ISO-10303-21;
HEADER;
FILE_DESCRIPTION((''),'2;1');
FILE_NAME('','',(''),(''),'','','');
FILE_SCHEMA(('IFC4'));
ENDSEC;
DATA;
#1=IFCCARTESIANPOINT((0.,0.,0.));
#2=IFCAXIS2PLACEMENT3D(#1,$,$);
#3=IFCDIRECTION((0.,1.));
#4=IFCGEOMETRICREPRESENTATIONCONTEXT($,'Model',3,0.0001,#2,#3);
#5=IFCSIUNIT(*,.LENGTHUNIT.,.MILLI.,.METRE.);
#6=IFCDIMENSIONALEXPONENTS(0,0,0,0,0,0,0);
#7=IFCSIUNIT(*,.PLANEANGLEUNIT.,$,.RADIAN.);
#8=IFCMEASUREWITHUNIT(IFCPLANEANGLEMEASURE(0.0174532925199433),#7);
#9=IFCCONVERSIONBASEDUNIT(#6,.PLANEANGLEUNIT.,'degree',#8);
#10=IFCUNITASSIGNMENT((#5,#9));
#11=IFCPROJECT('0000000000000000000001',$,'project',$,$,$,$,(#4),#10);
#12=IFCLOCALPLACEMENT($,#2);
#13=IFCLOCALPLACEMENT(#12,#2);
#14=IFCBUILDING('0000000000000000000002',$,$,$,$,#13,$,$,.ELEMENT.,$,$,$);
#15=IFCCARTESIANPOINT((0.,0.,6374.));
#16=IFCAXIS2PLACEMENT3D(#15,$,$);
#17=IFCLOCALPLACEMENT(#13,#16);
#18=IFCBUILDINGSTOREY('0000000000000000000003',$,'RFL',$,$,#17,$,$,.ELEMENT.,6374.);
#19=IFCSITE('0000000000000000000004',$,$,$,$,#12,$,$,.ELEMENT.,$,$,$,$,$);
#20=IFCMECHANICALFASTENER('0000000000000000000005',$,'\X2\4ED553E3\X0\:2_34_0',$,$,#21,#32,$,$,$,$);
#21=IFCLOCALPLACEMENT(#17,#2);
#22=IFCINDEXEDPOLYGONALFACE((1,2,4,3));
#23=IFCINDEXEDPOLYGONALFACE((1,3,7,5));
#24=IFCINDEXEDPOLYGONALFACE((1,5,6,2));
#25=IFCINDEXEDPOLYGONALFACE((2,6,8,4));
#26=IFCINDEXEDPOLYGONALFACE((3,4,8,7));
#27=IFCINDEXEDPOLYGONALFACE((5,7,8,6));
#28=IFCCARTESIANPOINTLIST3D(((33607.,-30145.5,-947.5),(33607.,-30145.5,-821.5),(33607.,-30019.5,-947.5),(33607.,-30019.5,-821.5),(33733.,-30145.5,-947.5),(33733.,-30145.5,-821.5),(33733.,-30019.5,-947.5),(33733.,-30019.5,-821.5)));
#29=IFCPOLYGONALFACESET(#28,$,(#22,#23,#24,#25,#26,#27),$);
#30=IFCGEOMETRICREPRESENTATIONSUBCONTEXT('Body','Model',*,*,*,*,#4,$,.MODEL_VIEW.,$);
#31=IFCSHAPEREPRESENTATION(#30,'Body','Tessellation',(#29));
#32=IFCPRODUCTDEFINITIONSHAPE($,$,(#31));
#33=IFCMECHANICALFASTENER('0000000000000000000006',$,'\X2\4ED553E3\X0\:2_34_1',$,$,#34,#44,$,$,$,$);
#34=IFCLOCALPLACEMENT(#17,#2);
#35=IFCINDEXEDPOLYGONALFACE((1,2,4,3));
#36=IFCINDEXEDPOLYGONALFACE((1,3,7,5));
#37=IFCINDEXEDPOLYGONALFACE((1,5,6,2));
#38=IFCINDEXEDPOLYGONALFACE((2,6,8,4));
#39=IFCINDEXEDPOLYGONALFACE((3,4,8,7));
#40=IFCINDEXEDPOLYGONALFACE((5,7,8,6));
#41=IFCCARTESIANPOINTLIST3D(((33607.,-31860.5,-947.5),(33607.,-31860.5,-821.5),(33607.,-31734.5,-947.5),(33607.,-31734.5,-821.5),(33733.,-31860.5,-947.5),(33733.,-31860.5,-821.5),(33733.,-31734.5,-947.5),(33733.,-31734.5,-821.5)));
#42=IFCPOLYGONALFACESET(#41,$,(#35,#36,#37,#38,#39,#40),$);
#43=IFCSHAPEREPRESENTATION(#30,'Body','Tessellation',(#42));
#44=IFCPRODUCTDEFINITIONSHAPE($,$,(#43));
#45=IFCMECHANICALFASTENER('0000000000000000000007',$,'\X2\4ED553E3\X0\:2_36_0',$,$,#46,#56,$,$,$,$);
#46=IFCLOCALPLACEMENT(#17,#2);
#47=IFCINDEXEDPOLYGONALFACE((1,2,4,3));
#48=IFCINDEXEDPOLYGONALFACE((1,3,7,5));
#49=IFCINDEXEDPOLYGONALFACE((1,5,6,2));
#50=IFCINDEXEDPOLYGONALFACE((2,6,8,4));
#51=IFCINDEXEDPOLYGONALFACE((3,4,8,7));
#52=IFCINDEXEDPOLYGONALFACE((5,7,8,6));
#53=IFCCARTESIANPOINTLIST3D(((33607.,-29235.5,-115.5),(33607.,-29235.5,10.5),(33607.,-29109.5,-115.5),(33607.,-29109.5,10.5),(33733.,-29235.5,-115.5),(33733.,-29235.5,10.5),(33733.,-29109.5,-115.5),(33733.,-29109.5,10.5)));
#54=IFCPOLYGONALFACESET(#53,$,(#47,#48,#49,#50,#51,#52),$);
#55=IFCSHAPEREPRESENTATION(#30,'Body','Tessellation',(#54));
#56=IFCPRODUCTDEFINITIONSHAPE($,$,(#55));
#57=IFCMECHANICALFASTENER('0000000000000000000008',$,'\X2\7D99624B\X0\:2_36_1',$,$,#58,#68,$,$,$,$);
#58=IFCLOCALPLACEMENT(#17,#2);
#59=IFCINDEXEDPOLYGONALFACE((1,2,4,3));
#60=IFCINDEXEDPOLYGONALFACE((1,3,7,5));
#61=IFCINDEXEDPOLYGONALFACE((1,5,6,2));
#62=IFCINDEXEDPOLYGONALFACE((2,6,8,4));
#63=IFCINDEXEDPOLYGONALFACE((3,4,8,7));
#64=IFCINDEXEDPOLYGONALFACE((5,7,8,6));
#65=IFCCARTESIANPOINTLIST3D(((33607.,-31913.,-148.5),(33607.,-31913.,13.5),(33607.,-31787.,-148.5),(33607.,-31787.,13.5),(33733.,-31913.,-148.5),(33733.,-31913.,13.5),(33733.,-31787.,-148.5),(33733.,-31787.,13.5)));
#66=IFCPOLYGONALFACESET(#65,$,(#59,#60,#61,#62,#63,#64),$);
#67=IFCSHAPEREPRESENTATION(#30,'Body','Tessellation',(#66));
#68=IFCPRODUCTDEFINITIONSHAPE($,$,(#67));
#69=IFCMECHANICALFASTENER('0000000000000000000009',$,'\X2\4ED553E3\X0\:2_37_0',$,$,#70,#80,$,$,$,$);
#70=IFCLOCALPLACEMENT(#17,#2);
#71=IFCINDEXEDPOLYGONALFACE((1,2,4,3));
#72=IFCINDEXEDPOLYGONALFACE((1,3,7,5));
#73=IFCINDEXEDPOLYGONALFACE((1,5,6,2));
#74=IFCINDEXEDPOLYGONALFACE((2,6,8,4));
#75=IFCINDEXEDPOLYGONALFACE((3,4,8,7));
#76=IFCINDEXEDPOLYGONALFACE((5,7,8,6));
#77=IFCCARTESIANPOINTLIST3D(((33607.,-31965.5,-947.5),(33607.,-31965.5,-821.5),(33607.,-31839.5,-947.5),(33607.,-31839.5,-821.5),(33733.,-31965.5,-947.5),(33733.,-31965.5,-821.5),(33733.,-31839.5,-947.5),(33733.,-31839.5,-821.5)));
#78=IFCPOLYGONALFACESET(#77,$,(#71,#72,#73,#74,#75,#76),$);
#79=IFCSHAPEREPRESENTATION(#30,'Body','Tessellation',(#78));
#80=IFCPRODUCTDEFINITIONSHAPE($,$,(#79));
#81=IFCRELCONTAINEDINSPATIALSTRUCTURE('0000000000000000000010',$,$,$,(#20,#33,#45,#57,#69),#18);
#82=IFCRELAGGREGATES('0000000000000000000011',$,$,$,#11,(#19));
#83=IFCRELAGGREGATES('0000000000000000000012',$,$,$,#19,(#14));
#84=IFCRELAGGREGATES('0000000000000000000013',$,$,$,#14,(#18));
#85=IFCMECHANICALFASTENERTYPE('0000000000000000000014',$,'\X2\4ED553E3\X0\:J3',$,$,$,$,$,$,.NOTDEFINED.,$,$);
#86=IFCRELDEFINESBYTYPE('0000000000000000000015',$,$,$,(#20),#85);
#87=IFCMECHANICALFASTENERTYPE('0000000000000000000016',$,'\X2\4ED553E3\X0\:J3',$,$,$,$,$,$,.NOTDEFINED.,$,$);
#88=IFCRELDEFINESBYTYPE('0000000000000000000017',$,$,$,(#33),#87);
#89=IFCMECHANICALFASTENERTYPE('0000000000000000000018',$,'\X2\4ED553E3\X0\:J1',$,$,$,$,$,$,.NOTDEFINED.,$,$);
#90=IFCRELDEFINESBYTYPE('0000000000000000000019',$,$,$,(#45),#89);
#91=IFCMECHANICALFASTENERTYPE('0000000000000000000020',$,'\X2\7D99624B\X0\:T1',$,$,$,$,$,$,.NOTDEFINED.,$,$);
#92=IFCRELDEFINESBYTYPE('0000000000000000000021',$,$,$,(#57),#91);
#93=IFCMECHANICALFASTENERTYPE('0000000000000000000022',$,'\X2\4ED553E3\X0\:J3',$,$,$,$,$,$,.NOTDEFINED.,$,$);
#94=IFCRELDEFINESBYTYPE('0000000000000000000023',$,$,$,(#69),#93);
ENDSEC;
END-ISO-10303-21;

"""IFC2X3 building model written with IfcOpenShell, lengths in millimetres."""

from ifc_helpers import new_model, entity, si_unit, converted_unit, direction, frame, origin, origin_with_axes, origin_2d, place, context, subcontext, project, spatial, rectangle, extrude, type_object, element, save


model = new_model("IFC2X3")

# Units and contexts
model_context = context("Model", 3, precision=0.0001, world=origin(), true_north=direction((0.0, 1.0)))
body_context = subcontext(model_context, "Body", "Model", "MODEL_VIEW")
ifc_project = project(units=[si_unit("LENGTHUNIT", "METRE", prefix="MILLI"), converted_unit("PLANEANGLEUNIT", "degree", entity("IfcPlaneAngleMeasure", 0.0174532925199433), si_unit("PLANEANGLEUNIT", "RADIAN"), dimensions=[0, 0, 0, 0, 0, 0, 0])], contexts=[model_context])

# Site, building, storey
site_placement = place(None, origin())
site = spatial("IfcSite", under=ifc_project, at=site_placement, CompositionType="ELEMENT")
building_placement = place(site_placement, origin())
building = spatial("IfcBuilding", under=site, at=building_placement, CompositionType="ELEMENT")
storey_placement = place(building_placement, frame((0.0, 0.0, 6374.0)))
storey = spatial("IfcBuildingStorey", under=building, at=storey_placement, Name="RFL", CompositionType="ELEMENT", Elevation=6374.0)

# Mechanical fasteners
mechanical_fastener_type_1 = type_object("IfcMechanicalFastenerType", Name="仕口:J3")
mechanical_fastener_1_placement = place(storey_placement, frame((33670.0, -30082.5, -947.5)))
element("IfcMechanicalFastener", 1, at=mechanical_fastener_1_placement, inside=storey, type_object=mechanical_fastener_type_1, Name="仕口:2_34_0", context=body_context, shape_type="SweptSolid", body=[
    extrude(rectangle(XDim=126.0, YDim=126.0, at=origin_2d()), origin_with_axes(), (0.0, 0.0, 1.0), 126.0),
])
mechanical_fastener_type_2 = type_object("IfcMechanicalFastenerType", Name="仕口:J3")
mechanical_fastener_2_placement = place(storey_placement, frame((33670.0, -31797.5, -947.5)))
element("IfcMechanicalFastener", 2, at=mechanical_fastener_2_placement, inside=storey, type_object=mechanical_fastener_type_2, Name="仕口:2_34_1", context=body_context, shape_type="SweptSolid", body=[
    extrude(rectangle(XDim=126.0, YDim=126.0, at=origin_2d()), origin_with_axes(), (0.0, 0.0, 1.0), 126.0),
])
mechanical_fastener_type_3 = type_object("IfcMechanicalFastenerType", Name="仕口:J1")
mechanical_fastener_3_placement = place(storey_placement, frame((33670.0, -29172.5, -115.5)))
element("IfcMechanicalFastener", 3, at=mechanical_fastener_3_placement, inside=storey, type_object=mechanical_fastener_type_3, Name="仕口:2_36_0", context=body_context, shape_type="SweptSolid", body=[
    extrude(rectangle(XDim=126.0, YDim=126.0, at=origin_2d()), origin_with_axes(), (0.0, 0.0, 1.0), 126.0),
])
mechanical_fastener_type_4 = type_object("IfcMechanicalFastenerType", Name="継手:T1")
mechanical_fastener_4_placement = place(storey_placement, frame((33670.0, -31850.0, -148.5)))
element("IfcMechanicalFastener", 4, at=mechanical_fastener_4_placement, inside=storey, type_object=mechanical_fastener_type_4, Name="継手:2_36_1", context=body_context, shape_type="SweptSolid", body=[
    extrude(rectangle(XDim=126.0, YDim=126.0, at=origin_2d()), origin_with_axes(), (0.0, 0.0, 1.0), 162.0),
])
mechanical_fastener_type_5 = type_object("IfcMechanicalFastenerType", Name="仕口:J3")
mechanical_fastener_5_placement = place(storey_placement, frame((33670.0, -31902.5, -947.5)))
element("IfcMechanicalFastener", 5, at=mechanical_fastener_5_placement, inside=storey, type_object=mechanical_fastener_type_5, Name="仕口:2_37_0", context=body_context, shape_type="SweptSolid", body=[
    extrude(rectangle(XDim=126.0, YDim=126.0, at=origin_2d()), origin_with_axes(), (0.0, 0.0, 1.0), 126.0),
])

save(model, "model.ifc")
